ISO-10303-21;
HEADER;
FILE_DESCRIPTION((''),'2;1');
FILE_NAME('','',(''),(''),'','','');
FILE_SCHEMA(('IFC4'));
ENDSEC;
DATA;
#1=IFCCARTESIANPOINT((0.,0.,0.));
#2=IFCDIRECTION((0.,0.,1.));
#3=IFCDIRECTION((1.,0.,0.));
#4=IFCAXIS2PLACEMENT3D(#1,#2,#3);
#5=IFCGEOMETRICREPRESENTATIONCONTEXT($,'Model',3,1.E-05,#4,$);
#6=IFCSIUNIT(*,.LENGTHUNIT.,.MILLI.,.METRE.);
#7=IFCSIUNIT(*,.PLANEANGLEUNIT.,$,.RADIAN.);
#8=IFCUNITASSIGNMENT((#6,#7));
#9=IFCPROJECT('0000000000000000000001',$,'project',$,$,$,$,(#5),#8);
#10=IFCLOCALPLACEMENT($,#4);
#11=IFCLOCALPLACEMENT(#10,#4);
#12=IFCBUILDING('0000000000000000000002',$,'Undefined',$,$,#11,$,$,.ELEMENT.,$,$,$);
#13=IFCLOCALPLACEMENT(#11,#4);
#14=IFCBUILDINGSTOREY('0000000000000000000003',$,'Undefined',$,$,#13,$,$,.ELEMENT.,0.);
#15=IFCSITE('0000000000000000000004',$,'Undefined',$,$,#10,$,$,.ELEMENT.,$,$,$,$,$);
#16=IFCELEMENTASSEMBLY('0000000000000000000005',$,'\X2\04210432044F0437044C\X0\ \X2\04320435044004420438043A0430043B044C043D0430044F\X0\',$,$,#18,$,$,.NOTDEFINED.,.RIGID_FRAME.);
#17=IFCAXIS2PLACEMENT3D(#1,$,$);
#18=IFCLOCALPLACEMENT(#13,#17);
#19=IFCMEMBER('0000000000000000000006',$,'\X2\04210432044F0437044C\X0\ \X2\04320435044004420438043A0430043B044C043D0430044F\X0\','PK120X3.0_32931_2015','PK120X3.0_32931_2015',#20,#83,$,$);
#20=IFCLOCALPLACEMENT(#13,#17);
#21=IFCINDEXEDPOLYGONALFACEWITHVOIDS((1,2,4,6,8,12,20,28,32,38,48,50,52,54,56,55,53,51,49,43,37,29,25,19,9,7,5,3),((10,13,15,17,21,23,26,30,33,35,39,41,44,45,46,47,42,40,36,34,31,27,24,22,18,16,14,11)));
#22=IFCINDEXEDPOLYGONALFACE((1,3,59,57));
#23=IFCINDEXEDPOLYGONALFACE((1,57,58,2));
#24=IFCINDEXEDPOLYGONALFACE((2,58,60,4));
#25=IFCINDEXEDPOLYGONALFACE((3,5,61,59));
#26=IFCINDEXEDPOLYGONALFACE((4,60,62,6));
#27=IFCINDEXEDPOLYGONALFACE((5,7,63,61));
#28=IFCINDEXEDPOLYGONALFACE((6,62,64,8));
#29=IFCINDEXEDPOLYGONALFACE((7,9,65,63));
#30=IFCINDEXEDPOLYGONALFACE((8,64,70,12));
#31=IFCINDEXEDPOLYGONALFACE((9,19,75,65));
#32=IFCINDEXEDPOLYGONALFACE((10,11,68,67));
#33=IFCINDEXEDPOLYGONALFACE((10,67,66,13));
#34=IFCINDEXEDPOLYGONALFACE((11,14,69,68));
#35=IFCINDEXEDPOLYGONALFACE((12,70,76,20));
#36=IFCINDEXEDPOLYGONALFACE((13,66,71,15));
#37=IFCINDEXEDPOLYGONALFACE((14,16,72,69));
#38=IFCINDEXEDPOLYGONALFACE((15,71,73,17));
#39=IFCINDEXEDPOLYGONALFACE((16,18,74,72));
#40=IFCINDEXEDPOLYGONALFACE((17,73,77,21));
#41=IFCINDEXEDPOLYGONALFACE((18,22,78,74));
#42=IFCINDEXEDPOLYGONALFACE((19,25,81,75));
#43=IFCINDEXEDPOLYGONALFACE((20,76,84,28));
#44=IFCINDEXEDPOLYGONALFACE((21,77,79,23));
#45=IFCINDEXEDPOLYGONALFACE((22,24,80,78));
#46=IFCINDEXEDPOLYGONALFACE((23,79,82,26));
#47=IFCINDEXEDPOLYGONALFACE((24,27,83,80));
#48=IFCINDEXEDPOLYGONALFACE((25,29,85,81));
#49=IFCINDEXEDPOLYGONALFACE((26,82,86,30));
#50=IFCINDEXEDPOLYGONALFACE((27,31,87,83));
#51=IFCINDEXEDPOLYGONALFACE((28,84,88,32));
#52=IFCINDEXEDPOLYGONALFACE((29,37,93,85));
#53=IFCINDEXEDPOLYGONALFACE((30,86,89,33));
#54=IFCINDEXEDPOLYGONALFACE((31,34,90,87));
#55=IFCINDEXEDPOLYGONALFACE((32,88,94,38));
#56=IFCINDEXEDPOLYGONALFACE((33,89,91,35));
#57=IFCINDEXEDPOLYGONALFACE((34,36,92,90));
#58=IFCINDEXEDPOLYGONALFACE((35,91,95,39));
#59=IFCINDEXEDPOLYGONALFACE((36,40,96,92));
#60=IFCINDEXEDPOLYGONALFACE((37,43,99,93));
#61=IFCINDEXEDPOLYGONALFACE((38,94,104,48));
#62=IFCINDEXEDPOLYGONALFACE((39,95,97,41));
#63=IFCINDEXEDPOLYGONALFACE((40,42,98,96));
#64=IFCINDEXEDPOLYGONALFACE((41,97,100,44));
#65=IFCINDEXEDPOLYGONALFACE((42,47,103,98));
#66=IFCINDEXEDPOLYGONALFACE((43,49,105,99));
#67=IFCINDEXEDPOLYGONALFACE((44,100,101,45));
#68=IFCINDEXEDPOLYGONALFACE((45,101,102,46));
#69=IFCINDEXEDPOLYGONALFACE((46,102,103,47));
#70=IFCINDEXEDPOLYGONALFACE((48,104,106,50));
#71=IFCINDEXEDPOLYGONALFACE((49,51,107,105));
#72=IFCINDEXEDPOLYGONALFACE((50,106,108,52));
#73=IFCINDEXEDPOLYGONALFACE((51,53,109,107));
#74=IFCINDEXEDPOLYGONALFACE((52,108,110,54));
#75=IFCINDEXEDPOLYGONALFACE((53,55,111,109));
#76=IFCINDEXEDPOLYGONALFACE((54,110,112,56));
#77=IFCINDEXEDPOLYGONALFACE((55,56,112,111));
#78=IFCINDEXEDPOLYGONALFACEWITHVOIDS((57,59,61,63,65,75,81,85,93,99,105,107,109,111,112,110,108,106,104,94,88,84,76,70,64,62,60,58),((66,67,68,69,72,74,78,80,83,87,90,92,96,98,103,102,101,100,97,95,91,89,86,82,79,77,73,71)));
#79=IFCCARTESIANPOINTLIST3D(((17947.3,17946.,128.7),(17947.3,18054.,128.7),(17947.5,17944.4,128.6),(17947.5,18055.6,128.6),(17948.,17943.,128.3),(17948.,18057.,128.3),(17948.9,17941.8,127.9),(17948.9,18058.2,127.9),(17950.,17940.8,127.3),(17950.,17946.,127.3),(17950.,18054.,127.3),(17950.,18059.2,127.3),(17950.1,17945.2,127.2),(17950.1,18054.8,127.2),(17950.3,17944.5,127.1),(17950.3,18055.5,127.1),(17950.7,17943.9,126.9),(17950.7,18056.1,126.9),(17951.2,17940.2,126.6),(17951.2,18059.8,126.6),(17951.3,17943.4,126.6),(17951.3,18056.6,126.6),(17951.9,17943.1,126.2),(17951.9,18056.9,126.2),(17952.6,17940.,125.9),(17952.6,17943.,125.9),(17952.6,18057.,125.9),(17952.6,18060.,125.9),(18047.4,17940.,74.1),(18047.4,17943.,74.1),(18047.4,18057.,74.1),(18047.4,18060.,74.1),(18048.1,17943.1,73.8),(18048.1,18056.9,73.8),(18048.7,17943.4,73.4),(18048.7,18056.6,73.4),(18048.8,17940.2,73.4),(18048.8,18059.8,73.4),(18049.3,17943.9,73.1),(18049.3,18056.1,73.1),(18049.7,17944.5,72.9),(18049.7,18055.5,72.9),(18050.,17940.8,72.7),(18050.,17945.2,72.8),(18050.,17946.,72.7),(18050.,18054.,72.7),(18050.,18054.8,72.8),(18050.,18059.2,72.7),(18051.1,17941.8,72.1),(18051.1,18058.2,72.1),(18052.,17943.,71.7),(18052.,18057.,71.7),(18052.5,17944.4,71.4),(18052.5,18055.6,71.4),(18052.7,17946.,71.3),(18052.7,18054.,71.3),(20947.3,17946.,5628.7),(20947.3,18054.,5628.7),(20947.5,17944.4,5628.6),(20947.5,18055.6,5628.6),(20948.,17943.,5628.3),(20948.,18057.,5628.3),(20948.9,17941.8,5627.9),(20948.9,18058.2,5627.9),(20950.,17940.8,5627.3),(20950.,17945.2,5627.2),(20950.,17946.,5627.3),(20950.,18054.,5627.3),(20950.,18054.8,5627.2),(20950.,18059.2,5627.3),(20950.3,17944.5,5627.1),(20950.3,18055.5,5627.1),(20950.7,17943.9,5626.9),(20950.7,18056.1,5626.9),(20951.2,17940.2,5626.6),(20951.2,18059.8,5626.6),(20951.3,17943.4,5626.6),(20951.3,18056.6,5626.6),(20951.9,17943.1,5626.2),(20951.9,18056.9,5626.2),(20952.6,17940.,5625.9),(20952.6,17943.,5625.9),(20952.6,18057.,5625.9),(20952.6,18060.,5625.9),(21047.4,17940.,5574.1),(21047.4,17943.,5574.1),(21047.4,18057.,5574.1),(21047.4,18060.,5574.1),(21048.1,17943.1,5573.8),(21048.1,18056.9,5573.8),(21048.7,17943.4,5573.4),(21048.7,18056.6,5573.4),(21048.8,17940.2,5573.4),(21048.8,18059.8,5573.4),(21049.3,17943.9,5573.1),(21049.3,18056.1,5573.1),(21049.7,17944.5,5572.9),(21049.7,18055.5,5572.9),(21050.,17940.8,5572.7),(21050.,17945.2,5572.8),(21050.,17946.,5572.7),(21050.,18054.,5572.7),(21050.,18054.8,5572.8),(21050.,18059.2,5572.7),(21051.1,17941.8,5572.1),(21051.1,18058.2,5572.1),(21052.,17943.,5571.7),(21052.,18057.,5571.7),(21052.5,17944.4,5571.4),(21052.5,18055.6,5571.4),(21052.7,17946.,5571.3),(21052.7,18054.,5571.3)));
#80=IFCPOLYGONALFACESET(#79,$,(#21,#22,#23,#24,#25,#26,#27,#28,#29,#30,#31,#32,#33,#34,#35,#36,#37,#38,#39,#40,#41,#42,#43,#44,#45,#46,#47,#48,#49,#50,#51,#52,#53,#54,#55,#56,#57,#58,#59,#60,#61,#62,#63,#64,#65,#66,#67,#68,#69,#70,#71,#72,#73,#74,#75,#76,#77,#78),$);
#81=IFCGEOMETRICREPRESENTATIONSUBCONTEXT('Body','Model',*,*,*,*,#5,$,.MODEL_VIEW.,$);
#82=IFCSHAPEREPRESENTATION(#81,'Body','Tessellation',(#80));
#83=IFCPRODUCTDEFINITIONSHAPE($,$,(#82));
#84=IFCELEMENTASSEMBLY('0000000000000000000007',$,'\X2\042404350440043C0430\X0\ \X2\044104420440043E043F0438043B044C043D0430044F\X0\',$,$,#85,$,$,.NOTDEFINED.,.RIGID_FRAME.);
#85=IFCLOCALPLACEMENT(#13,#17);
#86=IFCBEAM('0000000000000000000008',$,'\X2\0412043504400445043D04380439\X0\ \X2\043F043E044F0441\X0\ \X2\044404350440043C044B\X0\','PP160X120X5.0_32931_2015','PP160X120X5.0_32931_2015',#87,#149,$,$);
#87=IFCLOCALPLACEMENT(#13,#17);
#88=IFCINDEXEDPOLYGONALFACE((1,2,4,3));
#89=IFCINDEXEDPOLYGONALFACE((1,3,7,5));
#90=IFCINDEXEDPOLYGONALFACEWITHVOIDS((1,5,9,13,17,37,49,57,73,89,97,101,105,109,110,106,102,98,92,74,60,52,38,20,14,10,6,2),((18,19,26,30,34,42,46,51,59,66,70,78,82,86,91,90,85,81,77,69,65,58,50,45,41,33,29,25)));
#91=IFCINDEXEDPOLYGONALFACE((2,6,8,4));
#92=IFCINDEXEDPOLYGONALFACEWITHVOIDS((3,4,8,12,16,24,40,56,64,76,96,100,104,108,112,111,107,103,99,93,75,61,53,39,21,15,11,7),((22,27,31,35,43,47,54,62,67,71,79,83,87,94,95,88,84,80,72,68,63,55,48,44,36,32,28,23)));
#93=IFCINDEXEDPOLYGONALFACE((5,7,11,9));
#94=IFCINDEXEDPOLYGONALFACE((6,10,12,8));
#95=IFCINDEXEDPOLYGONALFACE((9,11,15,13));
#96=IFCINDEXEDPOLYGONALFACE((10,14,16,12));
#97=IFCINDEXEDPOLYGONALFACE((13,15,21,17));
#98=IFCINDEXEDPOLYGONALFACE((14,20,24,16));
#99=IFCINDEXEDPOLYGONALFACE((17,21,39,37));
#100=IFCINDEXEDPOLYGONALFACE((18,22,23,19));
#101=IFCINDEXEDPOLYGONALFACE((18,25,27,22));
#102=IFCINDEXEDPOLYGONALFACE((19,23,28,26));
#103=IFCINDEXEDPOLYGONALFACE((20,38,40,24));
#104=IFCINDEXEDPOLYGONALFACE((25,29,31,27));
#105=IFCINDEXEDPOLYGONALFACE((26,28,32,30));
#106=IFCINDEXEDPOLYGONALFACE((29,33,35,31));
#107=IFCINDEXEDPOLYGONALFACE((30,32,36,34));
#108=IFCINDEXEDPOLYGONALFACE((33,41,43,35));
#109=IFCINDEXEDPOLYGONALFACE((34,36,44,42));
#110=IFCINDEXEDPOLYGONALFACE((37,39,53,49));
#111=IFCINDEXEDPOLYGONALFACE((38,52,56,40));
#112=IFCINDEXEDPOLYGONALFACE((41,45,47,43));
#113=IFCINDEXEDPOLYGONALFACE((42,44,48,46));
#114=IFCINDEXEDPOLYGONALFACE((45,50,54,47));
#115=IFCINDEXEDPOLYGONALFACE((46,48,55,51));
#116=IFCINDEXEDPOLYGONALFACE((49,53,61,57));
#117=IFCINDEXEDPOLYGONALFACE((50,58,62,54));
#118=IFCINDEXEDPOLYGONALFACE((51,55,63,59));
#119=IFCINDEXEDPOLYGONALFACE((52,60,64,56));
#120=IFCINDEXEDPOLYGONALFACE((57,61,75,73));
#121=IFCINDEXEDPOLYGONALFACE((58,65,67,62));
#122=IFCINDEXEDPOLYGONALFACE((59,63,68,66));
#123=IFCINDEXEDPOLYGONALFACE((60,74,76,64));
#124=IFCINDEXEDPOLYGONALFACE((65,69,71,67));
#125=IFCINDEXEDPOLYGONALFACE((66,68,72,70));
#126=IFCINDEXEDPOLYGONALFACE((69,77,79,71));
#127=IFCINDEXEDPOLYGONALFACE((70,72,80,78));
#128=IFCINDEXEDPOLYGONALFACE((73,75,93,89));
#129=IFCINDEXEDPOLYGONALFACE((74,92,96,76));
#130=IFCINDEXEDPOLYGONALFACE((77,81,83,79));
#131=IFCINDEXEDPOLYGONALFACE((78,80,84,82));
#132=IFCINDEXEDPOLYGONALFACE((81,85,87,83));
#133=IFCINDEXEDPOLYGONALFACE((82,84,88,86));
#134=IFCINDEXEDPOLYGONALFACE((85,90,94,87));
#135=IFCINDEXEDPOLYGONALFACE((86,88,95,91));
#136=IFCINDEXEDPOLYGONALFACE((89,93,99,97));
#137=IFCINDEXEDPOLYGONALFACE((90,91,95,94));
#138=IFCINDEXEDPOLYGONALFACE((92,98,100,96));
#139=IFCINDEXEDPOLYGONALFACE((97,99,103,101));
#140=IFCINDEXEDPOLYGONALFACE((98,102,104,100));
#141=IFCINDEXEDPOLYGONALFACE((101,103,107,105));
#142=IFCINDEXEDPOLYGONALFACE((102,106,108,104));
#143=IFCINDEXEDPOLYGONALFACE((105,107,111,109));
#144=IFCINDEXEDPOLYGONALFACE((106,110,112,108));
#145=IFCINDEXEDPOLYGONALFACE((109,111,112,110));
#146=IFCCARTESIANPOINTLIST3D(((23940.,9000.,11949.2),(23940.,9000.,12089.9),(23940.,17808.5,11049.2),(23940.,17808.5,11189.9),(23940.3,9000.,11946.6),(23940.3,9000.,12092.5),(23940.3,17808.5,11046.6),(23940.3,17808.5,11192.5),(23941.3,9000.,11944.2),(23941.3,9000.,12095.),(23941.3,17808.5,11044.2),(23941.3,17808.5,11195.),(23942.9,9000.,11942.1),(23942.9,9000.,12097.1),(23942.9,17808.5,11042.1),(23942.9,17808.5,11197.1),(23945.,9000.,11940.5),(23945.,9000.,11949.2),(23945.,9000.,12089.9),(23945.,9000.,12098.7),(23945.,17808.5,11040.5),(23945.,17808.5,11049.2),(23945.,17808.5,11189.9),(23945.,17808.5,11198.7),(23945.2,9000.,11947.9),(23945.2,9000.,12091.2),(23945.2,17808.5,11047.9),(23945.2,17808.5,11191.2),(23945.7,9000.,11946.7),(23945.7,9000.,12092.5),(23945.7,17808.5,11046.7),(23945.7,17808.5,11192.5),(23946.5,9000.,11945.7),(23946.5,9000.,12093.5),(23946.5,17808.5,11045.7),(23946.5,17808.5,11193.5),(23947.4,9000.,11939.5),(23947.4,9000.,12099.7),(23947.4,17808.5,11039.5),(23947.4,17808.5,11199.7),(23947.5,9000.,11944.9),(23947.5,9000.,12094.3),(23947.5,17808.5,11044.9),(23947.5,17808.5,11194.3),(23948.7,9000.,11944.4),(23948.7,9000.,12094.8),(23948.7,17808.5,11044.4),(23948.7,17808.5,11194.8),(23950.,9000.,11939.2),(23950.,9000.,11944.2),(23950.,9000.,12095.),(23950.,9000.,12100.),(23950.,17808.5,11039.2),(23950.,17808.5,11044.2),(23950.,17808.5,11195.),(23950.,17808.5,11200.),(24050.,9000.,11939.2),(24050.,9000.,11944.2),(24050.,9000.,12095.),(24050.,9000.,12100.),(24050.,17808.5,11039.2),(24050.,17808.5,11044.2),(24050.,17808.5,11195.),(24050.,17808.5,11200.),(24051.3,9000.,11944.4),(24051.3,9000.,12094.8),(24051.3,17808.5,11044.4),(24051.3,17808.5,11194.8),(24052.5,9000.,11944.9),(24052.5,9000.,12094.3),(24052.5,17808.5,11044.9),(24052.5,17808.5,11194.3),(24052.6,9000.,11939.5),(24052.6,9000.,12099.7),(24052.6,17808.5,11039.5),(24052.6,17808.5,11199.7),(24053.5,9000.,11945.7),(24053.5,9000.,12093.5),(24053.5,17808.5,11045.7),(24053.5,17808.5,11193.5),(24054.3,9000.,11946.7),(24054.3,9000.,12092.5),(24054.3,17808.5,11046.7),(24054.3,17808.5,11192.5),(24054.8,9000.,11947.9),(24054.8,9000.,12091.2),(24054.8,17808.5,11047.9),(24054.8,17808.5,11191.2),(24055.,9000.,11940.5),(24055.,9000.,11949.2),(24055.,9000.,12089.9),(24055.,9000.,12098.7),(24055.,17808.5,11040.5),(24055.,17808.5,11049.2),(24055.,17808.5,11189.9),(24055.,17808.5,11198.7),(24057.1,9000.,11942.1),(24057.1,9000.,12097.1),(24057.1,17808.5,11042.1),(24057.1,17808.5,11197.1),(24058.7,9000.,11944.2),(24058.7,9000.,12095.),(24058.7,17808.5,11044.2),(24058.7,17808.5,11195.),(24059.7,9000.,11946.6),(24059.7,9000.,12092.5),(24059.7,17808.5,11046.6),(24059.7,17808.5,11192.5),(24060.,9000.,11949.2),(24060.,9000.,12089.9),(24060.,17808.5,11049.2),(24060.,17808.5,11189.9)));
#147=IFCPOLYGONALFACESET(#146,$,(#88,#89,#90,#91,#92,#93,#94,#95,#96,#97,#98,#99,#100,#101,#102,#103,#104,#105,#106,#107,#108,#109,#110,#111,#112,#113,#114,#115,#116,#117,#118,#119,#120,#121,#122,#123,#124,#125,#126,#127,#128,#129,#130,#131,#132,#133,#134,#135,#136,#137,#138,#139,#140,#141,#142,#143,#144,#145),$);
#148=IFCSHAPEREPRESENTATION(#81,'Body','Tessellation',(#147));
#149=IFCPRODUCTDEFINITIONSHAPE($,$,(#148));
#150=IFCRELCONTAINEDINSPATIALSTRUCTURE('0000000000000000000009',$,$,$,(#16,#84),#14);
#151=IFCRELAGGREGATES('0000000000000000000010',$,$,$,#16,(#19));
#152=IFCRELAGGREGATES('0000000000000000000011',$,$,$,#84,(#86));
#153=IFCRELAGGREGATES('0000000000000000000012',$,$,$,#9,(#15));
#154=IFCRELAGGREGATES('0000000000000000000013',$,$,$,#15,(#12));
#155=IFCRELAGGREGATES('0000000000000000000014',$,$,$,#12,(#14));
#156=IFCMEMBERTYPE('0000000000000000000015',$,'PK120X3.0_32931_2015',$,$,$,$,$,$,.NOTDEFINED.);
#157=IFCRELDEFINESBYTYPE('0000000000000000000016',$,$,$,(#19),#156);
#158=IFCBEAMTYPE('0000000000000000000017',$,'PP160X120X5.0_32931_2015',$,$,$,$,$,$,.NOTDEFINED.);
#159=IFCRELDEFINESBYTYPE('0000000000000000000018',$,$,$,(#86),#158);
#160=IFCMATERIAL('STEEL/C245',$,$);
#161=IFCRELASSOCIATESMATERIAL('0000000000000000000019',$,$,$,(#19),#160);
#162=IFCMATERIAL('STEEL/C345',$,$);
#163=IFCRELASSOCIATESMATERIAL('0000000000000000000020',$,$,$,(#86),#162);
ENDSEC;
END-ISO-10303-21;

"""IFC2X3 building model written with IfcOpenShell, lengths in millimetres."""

from ifc_helpers import new_model, si_unit, frame, origin_with_axes, origin_2d_with_axis, place, context, subcontext, project, spatial, hollow_rectangle, extrude, clip, halfspace, material, type_object, element, aggregate, save


model = new_model("IFC2X3")

# Units and contexts
model_context = context("Model", 3, precision=1e-05, world=origin_with_axes())
body_context = subcontext(model_context, "Body", "Model", "MODEL_VIEW")
ifc_project = project(units=[si_unit("LENGTHUNIT", "METRE", prefix="MILLI"), si_unit("PLANEANGLEUNIT", "RADIAN")], contexts=[model_context])

# Site, building, storey
site_placement = place(None, origin_with_axes())
site = spatial("IfcSite", under=ifc_project, at=site_placement, Name="Undefined", CompositionType="ELEMENT")
building_placement = place(site_placement, origin_with_axes())
building = spatial("IfcBuilding", under=site, at=building_placement, Name="Undefined", CompositionType="ELEMENT")
storey_placement = place(building_placement, origin_with_axes())
storey = spatial("IfcBuildingStorey", under=building, at=storey_placement, Name="Undefined", CompositionType="ELEMENT", Elevation=0.0)

# Shared definitions
ifc_material_1 = material(Name="STEEL/C245")

# Element assemblies, member
member_type_1 = type_object("IfcMemberType", Name="PK120X3.0_32931_2015", PredefinedType="NOTDEFINED")
assembly_1_placement = place(storey_placement, origin_with_axes())
assembly_1 = element("IfcElementAssembly", 1, at=assembly_1_placement, inside=storey, Name="Связь вертикальная", AssemblyPlace="NOTDEFINED", PredefinedType="RIGID_FRAME")
member_1_placement = place(assembly_1_placement, frame((18000.0, 18000.0, 100.0), z_axis=(-0.877896, 0.0, 0.478852), x_axis=(0.478852, 0.0, 0.877896)))
member_1 = element("IfcMember", 2, at=member_1_placement, type_object=member_type_1, material=ifc_material_1, Name="Связь вертикальная", Description="PK120X3.0_32931_2015", ObjectType="PK120X3.0_32931_2015", context=body_context, shape_type="SweptSolid", body=[
    extrude(hollow_rectangle(XDim=120.0, YDim=120.0, WallThickness=3.0, InnerFilletRadius=3.0, OuterFilletRadius=6.0, at=origin_2d_with_axis()), frame((6265.0, 0.0, 0.0), z_axis=(-1.0, 0.0, 0.0), x_axis=(0.0, -1.0, 0.0)), (0.0, 0.0, 1.0), 6265.0),
])
aggregate(assembly_1, [member_1])
assembly_2_placement = place(storey_placement, origin_with_axes())
assembly_2 = element("IfcElementAssembly", 3, at=assembly_2_placement, inside=storey, Name="Ферма стропильная", AssemblyPlace="NOTDEFINED", PredefinedType="RIGID_FRAME")

# Beam
ifc_material_2 = material(Name="STEEL/C345")
beam_type_1 = type_object("IfcBeamType", Name="PP160X120X5.0_32931_2015", PredefinedType="NOTDEFINED")
beam_1_placement = place(assembly_2_placement, frame((24000.0, 17800.4, 11120.4), z_axis=(0.0, 0.101645, 0.994821), x_axis=(0.0, -0.994821, 0.101645)))
beam_1 = element("IfcBeam", 4, at=beam_1_placement, type_object=beam_type_1, material=ifc_material_2, Name="Верхний пояс фермы", Description="PP160X120X5.0_32931_2015", ObjectType="PP160X120X5.0_32931_2015", context=body_context, shape_type="Clipping", body=[
    clip(clip(extrude(hollow_rectangle(XDim=120.0, YDim=160.0, WallThickness=5.0, InnerFilletRadius=5.0, OuterFilletRadius=10.0, at=origin_2d_with_axis()), frame((8862.7, 0.0, 0.0), z_axis=(-1.0, 0.0, 0.0), x_axis=(0.0, -1.0, 0.0)), (0.0, 0.0, 1.0), 8887.4), halfspace(frame((8854.4, 0.0, 80.0), z_axis=(0.994821, 0.0, -0.101645), x_axis=(0.101645, 0.0, 0.994821)), False)), halfspace(frame((0.0, 0.0, 80.0), z_axis=(0.994821, 0.0, -0.101645), x_axis=(0.101645, 0.0, 0.994821)), True)),
])
aggregate(assembly_2, [beam_1])

save(model, "model.ifc")
